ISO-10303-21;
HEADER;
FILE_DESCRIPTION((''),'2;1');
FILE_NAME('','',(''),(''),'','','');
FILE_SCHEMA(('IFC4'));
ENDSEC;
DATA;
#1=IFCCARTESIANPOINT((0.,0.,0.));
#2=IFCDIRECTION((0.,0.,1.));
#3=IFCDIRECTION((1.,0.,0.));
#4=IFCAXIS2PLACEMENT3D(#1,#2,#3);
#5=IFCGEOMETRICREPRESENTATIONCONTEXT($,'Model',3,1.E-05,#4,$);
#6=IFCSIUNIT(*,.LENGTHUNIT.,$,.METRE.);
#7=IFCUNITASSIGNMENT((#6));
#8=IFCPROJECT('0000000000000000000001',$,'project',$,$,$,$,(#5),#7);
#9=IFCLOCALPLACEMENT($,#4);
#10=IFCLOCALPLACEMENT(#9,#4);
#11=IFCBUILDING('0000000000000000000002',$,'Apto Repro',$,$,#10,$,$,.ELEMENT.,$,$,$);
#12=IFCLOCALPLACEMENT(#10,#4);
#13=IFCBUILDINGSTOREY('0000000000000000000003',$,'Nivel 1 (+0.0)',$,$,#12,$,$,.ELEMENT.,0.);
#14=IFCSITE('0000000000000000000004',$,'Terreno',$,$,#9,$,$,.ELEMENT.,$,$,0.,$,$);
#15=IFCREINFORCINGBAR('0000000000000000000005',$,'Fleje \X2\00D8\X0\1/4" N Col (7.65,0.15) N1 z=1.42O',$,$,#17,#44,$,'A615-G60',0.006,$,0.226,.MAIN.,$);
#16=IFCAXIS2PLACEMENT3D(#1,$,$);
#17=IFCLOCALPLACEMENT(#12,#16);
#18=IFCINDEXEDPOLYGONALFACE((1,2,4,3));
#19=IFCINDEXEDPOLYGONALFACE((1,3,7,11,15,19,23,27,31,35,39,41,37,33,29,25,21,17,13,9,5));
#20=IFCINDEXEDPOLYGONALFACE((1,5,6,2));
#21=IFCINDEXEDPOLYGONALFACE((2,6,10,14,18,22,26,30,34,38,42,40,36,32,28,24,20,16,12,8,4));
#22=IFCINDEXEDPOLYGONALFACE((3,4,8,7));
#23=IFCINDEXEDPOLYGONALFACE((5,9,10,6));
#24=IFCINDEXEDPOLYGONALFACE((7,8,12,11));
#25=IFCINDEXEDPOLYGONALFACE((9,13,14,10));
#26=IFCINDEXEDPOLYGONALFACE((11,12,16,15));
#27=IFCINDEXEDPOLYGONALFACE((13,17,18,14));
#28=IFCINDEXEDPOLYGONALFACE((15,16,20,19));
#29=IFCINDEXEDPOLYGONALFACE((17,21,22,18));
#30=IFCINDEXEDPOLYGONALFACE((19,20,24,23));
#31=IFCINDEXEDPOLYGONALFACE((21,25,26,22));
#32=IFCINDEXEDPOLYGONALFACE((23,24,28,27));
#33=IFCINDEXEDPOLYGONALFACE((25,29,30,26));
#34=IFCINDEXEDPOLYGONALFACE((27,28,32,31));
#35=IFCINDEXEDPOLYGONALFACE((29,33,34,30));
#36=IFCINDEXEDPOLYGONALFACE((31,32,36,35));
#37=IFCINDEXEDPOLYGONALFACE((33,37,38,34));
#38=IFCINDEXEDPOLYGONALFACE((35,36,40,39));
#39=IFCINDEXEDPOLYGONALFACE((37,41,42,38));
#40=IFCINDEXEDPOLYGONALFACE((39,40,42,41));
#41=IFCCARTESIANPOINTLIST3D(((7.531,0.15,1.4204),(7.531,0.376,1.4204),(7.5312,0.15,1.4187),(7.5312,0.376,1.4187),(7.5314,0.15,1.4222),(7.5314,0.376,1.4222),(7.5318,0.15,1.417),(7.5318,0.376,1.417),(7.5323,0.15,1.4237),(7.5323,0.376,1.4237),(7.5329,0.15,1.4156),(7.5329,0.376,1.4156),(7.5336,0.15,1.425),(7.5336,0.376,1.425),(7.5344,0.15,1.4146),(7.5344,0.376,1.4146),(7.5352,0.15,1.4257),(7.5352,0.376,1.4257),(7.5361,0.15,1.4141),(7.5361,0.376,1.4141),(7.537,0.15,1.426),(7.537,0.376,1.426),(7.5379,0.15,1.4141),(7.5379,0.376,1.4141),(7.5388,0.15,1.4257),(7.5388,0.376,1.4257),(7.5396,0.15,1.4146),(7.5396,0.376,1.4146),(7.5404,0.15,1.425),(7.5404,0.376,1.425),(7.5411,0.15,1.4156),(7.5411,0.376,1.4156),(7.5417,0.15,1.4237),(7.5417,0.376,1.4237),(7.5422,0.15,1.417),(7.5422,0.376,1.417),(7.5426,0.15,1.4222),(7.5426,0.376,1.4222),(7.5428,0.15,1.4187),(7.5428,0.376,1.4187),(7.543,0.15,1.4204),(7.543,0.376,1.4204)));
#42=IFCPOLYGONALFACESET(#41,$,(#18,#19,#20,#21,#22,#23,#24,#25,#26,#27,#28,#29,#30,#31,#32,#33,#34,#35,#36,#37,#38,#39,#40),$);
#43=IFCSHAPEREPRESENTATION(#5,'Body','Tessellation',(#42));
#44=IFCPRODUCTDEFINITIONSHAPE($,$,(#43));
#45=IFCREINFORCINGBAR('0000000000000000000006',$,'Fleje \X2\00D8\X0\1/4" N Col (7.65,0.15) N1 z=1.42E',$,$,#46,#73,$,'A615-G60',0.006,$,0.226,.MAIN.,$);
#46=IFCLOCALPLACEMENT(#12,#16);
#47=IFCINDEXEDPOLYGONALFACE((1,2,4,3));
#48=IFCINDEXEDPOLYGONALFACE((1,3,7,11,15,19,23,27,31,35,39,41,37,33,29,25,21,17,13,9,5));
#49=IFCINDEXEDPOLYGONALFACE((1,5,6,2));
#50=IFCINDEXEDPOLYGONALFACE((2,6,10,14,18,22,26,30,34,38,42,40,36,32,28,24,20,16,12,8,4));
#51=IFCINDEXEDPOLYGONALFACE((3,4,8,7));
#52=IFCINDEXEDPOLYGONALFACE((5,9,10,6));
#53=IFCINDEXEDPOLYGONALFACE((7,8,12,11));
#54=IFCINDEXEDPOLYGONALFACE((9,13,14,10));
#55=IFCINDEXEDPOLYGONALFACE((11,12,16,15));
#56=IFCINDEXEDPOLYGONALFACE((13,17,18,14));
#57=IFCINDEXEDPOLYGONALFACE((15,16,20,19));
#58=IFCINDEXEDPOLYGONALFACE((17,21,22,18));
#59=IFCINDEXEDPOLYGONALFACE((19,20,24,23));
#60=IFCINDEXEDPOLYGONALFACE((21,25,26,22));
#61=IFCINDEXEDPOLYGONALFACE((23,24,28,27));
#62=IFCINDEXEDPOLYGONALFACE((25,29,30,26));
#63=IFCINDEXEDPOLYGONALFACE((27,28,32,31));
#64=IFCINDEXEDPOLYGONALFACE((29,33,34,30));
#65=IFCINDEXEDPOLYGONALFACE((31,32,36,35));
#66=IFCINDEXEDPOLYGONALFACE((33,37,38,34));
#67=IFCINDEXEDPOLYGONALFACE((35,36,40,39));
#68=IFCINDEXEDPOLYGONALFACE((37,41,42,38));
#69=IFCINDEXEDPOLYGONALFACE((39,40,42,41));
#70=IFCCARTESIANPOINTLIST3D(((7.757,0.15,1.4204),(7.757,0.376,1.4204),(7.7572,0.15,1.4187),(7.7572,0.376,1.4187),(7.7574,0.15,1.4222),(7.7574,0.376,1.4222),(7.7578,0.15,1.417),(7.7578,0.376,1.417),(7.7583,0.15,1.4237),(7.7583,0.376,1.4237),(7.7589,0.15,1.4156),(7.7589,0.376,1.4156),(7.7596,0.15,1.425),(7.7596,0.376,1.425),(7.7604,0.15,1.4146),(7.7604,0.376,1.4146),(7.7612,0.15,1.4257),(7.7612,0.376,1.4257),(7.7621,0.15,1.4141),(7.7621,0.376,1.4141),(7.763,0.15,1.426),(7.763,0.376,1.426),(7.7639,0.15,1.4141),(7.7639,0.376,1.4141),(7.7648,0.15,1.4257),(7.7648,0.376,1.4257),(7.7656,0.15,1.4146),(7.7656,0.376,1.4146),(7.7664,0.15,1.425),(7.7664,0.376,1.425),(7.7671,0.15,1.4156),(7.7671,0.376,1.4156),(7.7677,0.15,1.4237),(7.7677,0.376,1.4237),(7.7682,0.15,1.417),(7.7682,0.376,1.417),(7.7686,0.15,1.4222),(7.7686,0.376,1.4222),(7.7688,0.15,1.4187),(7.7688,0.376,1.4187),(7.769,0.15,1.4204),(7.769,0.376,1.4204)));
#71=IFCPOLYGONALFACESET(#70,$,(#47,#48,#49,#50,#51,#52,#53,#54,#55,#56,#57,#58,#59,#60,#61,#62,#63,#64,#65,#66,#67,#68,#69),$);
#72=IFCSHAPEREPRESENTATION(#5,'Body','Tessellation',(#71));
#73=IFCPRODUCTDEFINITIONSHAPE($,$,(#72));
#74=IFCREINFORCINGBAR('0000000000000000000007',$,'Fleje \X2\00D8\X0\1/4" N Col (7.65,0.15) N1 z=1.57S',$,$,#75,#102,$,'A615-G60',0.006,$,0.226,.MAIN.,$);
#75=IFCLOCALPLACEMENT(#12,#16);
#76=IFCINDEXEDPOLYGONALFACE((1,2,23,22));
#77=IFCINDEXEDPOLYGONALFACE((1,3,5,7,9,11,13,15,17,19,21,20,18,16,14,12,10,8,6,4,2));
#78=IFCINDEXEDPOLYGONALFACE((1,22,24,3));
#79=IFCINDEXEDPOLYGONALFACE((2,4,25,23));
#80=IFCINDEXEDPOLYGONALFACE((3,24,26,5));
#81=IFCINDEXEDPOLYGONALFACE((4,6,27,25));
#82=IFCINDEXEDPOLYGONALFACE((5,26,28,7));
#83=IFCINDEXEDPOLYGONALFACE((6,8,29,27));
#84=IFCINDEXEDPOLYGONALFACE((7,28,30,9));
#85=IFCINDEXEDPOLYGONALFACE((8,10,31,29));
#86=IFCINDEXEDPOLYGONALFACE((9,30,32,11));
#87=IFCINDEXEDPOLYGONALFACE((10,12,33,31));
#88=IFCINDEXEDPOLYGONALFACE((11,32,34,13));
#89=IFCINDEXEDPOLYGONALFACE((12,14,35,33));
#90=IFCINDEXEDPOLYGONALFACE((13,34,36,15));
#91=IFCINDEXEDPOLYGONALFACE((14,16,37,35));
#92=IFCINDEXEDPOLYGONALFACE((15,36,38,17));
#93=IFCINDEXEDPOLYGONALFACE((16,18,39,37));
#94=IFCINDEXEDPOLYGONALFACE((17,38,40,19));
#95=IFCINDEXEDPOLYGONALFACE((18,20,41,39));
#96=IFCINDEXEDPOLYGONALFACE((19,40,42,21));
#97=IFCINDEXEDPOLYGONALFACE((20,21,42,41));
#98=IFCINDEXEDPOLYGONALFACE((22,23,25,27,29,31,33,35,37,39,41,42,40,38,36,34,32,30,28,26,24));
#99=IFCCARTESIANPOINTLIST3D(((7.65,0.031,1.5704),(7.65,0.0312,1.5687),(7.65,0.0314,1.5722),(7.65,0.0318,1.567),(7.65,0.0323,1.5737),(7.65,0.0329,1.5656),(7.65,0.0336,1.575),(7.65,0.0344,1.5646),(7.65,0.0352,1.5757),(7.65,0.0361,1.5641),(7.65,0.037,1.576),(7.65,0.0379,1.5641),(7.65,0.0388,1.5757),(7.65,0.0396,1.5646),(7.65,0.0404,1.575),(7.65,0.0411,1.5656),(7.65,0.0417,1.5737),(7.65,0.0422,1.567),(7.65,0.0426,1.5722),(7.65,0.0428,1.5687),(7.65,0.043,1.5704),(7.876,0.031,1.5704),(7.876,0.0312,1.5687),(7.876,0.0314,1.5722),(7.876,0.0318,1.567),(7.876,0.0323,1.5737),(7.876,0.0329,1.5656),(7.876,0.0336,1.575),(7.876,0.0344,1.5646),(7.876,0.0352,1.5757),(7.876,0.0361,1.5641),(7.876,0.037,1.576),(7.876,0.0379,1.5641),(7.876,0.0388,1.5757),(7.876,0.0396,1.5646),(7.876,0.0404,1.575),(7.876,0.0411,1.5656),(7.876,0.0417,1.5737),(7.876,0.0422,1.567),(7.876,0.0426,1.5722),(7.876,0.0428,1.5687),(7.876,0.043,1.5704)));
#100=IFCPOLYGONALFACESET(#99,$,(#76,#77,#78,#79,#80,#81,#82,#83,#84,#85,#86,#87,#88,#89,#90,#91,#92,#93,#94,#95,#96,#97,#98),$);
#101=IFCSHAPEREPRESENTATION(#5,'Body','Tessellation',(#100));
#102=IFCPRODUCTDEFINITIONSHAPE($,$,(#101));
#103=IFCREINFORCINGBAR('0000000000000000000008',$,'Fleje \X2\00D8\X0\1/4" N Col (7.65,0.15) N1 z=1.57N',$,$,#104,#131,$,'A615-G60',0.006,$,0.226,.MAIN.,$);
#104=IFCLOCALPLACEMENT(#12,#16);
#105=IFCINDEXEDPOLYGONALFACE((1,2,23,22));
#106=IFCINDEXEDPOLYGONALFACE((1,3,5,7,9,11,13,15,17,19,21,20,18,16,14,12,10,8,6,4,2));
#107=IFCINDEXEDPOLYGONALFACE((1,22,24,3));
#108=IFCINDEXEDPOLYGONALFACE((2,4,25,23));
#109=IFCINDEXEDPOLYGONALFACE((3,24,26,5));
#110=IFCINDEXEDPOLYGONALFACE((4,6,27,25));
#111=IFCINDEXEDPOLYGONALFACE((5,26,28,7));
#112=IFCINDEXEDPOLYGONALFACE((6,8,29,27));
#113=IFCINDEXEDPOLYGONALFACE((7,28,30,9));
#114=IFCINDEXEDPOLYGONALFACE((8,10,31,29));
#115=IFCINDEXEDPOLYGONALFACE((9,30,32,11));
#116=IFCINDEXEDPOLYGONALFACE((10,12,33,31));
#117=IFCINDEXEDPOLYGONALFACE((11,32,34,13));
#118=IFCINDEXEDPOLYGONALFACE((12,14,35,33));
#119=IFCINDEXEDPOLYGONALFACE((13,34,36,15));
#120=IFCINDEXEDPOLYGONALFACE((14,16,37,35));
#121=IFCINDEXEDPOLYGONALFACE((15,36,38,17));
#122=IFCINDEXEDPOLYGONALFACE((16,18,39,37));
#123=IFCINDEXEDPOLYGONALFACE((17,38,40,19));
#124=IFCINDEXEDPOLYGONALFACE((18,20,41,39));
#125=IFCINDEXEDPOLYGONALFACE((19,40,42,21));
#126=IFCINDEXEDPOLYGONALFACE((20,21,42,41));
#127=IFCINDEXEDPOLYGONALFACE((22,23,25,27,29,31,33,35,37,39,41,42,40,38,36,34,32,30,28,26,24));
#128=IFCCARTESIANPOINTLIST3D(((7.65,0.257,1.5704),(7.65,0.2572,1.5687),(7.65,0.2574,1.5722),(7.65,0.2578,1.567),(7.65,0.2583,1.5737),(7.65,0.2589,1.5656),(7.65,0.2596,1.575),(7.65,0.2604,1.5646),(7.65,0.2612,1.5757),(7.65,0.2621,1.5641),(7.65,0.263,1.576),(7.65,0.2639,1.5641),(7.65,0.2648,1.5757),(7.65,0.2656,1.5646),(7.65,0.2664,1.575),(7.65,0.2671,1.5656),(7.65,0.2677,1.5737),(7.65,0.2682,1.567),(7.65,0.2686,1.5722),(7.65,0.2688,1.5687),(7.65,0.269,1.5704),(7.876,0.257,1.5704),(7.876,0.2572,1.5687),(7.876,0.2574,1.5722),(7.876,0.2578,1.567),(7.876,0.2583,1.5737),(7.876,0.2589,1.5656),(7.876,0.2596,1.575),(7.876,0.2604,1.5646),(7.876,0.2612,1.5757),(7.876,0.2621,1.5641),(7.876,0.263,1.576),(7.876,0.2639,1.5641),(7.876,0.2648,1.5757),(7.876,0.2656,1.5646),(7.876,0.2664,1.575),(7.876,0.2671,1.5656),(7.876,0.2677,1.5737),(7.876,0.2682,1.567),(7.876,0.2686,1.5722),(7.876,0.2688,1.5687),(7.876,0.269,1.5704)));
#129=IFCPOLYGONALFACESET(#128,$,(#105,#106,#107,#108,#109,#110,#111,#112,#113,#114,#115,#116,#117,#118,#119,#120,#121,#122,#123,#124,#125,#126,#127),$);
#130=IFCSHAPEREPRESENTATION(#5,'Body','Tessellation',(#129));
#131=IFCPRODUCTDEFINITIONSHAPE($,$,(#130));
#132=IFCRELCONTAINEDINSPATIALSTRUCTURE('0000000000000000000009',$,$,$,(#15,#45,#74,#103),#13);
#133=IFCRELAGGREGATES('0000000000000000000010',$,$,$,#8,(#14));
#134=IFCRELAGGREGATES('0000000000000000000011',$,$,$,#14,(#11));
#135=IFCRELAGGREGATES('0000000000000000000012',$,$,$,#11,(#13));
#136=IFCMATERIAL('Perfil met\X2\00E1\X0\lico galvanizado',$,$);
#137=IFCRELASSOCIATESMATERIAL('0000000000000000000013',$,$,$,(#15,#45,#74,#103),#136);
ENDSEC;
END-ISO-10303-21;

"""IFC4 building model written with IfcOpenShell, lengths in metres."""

from ifc_helpers import new_model, si_unit, frame, origin_with_axes, origin_2d_with_axis, place, context, project, spatial, circle, extrude, material, element, save


model = new_model("IFC4")

# Units and contexts
model_context = context("Model", 3, precision=1e-05, world=origin_with_axes())
ifc_project = project(units=[si_unit("LENGTHUNIT", "METRE")], contexts=[model_context])

# Site, building, storey
site_placement = place(None, origin_with_axes())
site = spatial("IfcSite", under=ifc_project, at=site_placement, Name="Terreno", CompositionType="ELEMENT", RefElevation=0.0)
building_placement = place(site_placement, origin_with_axes())
building = spatial("IfcBuilding", under=site, at=building_placement, Name="Apto Repro", CompositionType="ELEMENT")
storey_placement = place(building_placement, origin_with_axes())
storey = spatial("IfcBuildingStorey", under=building, at=storey_placement, Name="Nivel 1 (+0.0)", CompositionType="ELEMENT", Elevation=0.0)

# Reinforcing bars
ifc_material = material(Name="Perfil metálico galvanizado")
reinforcing_bar_1_placement = place(storey_placement, origin_with_axes())
element("IfcReinforcingBar", 1, at=reinforcing_bar_1_placement, inside=storey, material=ifc_material, Name="Fleje Ø1/4\" N Col (7.65,0.15) N1 z=1.42O", SteelGrade="A615-G60", BarLength=0.226, NominalDiameter=0.006, PredefinedType="MAIN", context=model_context, shape_type="SweptSolid", body=[
    extrude(circle(Radius=0.006, at=origin_2d_with_axis()), frame((7.537, 0.15, 1.42), z_axis=(0.0, 1.0, 0.0), x_axis=(0.0, 0.0, 1.0)), (0.0, 0.0, 1.0), 0.226),
])
reinforcing_bar_2_placement = place(storey_placement, origin_with_axes())
element("IfcReinforcingBar", 2, at=reinforcing_bar_2_placement, inside=storey, material=ifc_material, Name="Fleje Ø1/4\" N Col (7.65,0.15) N1 z=1.42E", SteelGrade="A615-G60", BarLength=0.226, NominalDiameter=0.006, PredefinedType="MAIN", context=model_context, shape_type="SweptSolid", body=[
    extrude(circle(Radius=0.006, at=origin_2d_with_axis()), frame((7.763, 0.15, 1.42), z_axis=(0.0, 1.0, 0.0), x_axis=(0.0, 0.0, 1.0)), (0.0, 0.0, 1.0), 0.226),
])
reinforcing_bar_3_placement = place(storey_placement, origin_with_axes())
element("IfcReinforcingBar", 3, at=reinforcing_bar_3_placement, inside=storey, material=ifc_material, Name="Fleje Ø1/4\" N Col (7.65,0.15) N1 z=1.57S", SteelGrade="A615-G60", BarLength=0.226, NominalDiameter=0.006, PredefinedType="MAIN", context=model_context, shape_type="SweptSolid", body=[
    extrude(circle(Radius=0.006, at=origin_2d_with_axis()), frame((7.65, 0.037, 1.57), z_axis=(1.0, 0.0, 0.0), x_axis=(0.0, 0.0, 1.0)), (0.0, 0.0, 1.0), 0.226),
])
reinforcing_bar_4_placement = place(storey_placement, origin_with_axes())
element("IfcReinforcingBar", 4, at=reinforcing_bar_4_placement, inside=storey, material=ifc_material, Name="Fleje Ø1/4\" N Col (7.65,0.15) N1 z=1.57N", SteelGrade="A615-G60", BarLength=0.226, NominalDiameter=0.006, PredefinedType="MAIN", context=model_context, shape_type="SweptSolid", body=[
    extrude(circle(Radius=0.006, at=origin_2d_with_axis()), frame((7.65, 0.263, 1.57), z_axis=(1.0, 0.0, 0.0), x_axis=(0.0, 0.0, 1.0)), (0.0, 0.0, 1.0), 0.226),
])

save(model, "model.ifc")
